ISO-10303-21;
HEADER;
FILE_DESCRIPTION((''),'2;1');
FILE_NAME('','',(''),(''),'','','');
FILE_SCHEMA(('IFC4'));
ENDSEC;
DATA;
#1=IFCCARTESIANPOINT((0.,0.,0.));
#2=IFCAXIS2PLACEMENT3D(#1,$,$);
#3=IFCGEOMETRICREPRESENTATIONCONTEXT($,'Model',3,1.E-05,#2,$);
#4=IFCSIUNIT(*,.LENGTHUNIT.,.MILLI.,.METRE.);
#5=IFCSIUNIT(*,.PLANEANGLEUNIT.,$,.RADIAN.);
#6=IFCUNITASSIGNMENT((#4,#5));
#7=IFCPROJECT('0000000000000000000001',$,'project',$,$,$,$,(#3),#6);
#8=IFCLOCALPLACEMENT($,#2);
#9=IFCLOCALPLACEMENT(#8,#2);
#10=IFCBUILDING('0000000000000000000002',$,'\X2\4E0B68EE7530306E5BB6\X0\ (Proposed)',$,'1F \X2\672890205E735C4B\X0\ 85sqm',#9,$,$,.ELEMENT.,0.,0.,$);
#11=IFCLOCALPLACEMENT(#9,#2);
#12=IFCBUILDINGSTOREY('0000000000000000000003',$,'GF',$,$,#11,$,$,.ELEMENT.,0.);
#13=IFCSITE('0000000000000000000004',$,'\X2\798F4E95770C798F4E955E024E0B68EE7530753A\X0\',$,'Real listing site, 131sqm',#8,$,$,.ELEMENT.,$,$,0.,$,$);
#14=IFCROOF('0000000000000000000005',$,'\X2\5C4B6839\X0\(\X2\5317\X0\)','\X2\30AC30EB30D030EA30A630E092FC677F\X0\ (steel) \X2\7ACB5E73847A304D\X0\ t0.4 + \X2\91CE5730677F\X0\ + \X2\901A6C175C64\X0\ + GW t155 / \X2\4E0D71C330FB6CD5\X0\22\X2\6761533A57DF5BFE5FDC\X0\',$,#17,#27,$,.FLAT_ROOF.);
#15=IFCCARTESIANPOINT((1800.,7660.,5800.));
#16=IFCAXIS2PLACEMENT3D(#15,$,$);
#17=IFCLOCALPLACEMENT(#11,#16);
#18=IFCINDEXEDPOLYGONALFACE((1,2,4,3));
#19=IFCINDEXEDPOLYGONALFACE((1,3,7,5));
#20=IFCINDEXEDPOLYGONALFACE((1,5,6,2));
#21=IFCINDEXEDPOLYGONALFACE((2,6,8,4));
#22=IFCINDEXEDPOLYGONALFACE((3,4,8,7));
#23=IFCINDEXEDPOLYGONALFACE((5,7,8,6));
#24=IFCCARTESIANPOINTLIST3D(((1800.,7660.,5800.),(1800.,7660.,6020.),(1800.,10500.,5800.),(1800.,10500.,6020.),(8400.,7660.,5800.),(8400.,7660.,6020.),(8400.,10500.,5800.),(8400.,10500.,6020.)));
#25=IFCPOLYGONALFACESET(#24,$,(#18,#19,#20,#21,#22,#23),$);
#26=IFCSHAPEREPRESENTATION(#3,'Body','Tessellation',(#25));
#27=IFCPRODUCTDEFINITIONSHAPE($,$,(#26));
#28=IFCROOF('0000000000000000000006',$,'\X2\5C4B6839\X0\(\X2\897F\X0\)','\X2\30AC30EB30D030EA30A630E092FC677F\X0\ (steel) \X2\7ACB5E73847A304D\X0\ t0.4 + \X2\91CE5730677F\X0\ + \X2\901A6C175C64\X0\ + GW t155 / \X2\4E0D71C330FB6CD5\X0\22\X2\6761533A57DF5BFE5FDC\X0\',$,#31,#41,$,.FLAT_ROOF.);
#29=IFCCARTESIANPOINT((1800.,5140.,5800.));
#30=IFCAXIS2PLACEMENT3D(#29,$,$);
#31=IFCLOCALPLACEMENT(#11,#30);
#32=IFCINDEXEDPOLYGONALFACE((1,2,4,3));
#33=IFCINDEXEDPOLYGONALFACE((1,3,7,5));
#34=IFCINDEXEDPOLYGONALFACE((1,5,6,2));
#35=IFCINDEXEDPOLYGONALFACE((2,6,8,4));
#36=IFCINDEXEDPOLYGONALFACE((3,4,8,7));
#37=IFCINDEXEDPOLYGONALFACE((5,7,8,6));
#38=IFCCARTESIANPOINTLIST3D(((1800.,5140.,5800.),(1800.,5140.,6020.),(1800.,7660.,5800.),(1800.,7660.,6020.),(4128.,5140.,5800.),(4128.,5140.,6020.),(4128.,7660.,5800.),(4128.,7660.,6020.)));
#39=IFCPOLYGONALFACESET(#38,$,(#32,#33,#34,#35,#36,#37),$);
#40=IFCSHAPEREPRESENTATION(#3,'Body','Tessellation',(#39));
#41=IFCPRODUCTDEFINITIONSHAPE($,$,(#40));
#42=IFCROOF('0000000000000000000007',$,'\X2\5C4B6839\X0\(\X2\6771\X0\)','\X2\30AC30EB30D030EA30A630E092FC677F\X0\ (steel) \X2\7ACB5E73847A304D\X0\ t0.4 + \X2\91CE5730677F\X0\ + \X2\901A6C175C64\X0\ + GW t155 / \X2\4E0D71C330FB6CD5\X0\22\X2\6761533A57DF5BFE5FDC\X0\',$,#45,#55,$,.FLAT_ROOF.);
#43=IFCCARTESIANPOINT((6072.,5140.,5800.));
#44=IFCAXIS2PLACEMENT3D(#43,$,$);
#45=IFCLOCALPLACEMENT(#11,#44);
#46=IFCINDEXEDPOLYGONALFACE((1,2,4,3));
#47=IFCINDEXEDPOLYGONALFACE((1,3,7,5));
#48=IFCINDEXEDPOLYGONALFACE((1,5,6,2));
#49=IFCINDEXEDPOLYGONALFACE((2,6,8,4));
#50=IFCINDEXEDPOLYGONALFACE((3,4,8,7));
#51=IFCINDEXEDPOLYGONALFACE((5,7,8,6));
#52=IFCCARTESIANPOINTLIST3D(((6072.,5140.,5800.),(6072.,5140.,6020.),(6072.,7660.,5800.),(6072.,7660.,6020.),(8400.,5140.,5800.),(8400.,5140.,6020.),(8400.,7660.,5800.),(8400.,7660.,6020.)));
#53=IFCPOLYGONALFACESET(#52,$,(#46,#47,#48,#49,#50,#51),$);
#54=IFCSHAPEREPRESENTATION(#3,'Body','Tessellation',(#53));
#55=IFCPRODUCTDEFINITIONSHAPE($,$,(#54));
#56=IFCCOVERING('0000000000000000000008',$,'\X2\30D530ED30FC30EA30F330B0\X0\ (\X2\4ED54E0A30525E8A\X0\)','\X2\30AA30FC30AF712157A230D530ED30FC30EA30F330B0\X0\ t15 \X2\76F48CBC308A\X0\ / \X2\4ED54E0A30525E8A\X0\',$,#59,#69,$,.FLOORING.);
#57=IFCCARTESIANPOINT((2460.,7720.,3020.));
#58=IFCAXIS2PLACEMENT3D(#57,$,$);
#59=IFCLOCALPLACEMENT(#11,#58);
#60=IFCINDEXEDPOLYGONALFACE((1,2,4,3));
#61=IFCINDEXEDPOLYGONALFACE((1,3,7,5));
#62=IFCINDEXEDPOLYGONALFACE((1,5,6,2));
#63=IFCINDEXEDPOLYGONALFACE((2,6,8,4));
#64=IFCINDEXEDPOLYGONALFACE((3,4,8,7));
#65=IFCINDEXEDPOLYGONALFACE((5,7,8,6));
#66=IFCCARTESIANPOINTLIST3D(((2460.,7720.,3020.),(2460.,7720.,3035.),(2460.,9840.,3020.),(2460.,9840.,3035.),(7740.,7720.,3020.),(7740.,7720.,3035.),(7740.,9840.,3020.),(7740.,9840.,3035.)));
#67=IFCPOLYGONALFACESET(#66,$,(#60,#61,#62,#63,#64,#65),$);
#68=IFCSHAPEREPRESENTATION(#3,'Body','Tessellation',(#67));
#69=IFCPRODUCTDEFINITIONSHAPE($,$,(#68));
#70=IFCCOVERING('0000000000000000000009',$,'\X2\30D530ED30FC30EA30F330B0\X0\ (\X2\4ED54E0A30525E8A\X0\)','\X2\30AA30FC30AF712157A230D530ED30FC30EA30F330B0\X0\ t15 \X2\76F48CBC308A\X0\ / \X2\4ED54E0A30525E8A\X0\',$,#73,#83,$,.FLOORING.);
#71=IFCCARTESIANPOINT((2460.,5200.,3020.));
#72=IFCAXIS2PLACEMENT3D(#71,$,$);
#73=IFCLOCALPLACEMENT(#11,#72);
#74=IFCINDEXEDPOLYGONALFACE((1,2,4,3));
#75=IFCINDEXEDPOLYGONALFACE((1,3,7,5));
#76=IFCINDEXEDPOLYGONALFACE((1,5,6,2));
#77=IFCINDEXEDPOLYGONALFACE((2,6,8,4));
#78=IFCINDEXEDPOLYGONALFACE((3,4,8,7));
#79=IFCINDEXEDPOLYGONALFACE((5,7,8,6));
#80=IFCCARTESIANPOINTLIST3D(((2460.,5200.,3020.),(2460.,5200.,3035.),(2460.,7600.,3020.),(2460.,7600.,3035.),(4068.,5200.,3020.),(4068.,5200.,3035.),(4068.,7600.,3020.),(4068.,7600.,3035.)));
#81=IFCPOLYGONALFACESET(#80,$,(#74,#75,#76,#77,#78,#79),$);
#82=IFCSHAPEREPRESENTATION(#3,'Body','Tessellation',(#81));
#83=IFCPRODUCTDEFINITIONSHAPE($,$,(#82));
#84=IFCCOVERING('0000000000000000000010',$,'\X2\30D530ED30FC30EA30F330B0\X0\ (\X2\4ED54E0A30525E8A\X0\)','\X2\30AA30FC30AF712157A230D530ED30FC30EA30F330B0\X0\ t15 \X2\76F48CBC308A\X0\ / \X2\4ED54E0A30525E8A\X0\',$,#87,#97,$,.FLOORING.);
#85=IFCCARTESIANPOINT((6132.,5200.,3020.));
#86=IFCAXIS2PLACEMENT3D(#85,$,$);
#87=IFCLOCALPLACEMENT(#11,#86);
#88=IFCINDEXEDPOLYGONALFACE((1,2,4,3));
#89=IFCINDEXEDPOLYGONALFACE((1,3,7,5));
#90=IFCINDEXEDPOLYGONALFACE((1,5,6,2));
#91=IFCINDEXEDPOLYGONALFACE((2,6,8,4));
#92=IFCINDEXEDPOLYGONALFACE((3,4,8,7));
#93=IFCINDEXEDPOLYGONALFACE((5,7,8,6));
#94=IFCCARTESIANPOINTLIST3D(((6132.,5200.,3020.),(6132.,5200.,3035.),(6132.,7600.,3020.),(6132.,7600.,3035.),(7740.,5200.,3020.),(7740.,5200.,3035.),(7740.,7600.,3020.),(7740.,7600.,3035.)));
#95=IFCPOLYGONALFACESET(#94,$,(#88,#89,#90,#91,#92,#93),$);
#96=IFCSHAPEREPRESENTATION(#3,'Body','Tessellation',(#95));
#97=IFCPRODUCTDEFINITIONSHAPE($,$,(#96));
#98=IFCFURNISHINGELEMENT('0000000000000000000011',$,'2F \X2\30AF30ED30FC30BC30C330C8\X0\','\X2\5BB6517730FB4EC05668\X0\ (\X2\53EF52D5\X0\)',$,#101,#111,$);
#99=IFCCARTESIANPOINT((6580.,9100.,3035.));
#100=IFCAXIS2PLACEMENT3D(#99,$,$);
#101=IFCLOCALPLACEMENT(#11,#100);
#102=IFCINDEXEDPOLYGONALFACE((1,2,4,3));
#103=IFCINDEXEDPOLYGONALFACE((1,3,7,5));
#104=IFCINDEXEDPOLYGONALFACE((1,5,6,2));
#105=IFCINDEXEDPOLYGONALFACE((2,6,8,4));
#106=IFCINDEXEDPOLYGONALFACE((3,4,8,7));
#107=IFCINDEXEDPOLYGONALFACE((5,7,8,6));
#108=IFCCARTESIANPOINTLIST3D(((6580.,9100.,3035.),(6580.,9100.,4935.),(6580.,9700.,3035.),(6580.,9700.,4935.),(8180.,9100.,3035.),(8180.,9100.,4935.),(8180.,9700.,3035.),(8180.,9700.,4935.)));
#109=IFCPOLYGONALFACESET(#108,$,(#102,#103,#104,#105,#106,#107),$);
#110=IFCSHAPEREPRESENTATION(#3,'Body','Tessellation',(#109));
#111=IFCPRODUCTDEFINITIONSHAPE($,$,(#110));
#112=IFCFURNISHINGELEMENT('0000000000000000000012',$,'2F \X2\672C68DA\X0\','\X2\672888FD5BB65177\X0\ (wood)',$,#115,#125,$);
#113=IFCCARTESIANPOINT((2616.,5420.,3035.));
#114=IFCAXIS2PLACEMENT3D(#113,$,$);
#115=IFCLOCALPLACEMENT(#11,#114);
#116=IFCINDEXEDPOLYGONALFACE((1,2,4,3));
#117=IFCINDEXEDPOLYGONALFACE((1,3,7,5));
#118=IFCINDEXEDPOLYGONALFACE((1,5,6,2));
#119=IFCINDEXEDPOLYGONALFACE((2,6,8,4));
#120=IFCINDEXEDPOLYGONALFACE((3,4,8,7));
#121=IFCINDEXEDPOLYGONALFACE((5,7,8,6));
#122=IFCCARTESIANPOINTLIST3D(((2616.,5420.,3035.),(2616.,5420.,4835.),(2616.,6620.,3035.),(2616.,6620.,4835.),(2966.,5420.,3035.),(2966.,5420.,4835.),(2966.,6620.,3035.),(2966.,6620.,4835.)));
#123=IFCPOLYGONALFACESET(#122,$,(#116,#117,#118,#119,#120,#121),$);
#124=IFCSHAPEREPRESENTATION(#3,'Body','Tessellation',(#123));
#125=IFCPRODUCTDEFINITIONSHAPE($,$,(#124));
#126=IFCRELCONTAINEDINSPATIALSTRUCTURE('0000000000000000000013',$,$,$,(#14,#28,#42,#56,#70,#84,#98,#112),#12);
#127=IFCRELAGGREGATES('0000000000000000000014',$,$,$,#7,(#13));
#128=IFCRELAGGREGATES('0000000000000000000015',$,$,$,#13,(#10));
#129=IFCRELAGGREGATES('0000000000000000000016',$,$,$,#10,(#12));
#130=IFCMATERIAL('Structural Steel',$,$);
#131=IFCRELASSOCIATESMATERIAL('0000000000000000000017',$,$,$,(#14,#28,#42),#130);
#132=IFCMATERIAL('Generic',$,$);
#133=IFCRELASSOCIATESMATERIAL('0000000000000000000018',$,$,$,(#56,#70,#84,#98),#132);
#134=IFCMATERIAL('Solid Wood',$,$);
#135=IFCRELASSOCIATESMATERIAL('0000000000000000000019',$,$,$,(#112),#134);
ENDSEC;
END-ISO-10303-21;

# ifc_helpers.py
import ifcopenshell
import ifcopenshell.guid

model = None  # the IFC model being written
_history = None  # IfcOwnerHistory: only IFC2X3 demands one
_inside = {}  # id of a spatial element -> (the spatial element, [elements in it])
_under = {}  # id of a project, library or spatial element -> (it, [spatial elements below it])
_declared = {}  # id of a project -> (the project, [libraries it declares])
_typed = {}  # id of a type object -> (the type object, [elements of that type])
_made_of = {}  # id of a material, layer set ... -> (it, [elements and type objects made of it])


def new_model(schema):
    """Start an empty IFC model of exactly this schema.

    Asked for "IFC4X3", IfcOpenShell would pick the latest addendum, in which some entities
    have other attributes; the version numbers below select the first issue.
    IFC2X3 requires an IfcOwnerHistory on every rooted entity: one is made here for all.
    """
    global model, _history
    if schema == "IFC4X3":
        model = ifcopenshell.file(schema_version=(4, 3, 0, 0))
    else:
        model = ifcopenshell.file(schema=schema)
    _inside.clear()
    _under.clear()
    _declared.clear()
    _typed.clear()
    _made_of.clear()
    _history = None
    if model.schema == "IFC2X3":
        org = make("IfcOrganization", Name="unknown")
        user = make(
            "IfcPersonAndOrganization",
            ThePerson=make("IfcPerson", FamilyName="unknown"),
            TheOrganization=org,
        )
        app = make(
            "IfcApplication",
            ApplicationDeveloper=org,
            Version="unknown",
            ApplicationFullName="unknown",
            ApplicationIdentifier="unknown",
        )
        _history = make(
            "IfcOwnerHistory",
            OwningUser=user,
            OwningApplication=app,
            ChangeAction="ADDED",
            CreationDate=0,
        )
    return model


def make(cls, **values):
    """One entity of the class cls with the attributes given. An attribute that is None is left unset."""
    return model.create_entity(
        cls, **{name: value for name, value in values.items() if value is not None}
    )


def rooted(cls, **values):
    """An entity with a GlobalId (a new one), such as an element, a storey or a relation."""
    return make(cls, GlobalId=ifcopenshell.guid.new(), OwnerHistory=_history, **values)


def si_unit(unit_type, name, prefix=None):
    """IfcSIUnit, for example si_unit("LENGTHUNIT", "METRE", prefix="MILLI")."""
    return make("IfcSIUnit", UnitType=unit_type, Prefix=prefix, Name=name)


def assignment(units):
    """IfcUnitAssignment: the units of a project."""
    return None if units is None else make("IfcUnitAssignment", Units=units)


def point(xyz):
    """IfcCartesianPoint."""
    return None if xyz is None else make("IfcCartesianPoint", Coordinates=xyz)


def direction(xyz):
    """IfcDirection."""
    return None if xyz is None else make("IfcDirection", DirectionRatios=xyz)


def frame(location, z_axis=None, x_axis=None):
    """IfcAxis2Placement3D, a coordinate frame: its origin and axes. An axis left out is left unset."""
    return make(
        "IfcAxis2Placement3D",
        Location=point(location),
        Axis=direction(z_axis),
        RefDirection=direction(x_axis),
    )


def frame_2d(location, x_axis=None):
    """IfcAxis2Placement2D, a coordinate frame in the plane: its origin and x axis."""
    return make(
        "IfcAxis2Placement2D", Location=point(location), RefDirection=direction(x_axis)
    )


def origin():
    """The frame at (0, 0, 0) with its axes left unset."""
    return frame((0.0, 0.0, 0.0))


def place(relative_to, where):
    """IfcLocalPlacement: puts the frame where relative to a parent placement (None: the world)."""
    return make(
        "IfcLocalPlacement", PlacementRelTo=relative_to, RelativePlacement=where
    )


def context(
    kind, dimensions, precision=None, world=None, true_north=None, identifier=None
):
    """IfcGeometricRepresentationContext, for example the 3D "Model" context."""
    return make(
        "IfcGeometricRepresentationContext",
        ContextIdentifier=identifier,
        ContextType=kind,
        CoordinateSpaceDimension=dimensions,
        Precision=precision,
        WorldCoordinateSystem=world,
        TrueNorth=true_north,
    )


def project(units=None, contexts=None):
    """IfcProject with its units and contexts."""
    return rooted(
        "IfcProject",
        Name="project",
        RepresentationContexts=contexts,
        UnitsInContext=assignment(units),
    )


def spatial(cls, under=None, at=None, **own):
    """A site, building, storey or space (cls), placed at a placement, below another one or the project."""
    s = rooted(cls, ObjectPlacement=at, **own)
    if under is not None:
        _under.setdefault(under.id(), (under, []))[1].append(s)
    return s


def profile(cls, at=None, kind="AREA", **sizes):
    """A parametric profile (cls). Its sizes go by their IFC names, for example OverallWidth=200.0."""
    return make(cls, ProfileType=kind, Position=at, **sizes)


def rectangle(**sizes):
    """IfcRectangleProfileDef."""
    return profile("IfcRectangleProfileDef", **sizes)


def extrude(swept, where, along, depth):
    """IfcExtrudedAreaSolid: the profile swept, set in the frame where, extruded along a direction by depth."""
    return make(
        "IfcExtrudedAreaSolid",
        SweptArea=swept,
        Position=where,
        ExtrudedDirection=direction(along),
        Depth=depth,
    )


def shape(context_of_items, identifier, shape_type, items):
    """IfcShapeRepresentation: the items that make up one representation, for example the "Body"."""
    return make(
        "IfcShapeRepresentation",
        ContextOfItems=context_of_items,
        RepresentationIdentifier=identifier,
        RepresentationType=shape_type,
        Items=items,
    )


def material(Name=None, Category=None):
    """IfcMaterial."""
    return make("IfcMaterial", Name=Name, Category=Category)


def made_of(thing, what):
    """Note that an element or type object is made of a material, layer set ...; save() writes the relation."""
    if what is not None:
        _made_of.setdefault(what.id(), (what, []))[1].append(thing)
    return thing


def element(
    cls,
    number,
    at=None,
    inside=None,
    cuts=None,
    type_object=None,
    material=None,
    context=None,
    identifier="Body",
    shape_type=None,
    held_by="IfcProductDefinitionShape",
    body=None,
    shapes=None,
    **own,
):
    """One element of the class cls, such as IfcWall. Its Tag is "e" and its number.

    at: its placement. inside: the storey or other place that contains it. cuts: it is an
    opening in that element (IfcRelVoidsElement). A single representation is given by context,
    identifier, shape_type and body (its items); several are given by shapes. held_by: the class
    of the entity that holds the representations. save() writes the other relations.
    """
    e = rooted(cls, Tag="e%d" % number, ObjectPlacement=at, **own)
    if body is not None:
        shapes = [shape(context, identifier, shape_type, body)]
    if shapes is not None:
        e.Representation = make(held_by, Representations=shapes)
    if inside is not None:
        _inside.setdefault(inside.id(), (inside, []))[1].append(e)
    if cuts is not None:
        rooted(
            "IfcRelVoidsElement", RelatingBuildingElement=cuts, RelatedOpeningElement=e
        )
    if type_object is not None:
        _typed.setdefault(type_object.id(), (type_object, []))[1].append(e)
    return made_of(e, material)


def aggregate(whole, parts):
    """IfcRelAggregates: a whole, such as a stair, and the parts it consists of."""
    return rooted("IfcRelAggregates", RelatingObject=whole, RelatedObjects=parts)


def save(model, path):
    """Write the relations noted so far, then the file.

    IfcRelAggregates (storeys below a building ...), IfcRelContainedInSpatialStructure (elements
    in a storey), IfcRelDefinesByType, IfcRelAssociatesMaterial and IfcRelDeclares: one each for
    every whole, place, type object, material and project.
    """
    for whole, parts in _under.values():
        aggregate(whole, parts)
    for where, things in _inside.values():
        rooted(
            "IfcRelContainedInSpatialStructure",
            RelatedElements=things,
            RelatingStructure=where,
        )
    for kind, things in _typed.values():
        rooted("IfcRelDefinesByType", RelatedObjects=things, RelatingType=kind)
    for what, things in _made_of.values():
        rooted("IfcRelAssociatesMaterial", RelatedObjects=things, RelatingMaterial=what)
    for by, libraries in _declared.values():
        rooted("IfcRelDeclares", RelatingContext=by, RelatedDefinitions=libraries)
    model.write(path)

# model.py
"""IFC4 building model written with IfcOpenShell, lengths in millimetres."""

from ifc_helpers import new_model, si_unit, frame, frame_2d, origin, place, context, project, spatial, rectangle, extrude, material, element, save


model = new_model("IFC4")

# Units and contexts
model_context = context("Model", 3, precision=1e-05, world=origin())
ifc_project = project(units=[si_unit("LENGTHUNIT", "METRE", prefix="MILLI"), si_unit("PLANEANGLEUNIT", "RADIAN")], contexts=[model_context])

# Site, building, storey
site_placement = place(None, origin())
site = spatial("IfcSite", under=ifc_project, at=site_placement, Name="福井県福井市下森田町", ObjectType="Real listing site, 131sqm", CompositionType="ELEMENT", RefElevation=0.0)
building_placement = place(site_placement, origin())
building = spatial("IfcBuilding", under=site, at=building_placement, Name="下森田の家 (Proposed)", ObjectType="1F 木造平屋 85sqm", CompositionType="ELEMENT", ElevationOfRefHeight=0.0, ElevationOfTerrain=0.0)
storey_placement = place(building_placement, origin())
storey = spatial("IfcBuildingStorey", under=building, at=storey_placement, Name="GF", CompositionType="ELEMENT", Elevation=0.0)

# Shared definitions
ifc_material_1 = material(Name="Solid Wood")

# Shared definitions
ifc_material_2 = material(Name="Generic")

# Roofs
ifc_material_3 = material(Name="Structural Steel")
for number, where, name in (
    (1, (1800.0, 7660.0, 5800.0), "屋根(北)"),
):
    element("IfcRoof", number, at=place(storey_placement, frame(where)), inside=storey, material=ifc_material_3, Name=name, Description="ガルバリウム鋼板 (steel) 立平葺き t0.4 + 野地板 + 通気層 + GW t155 / 不燃・法22条区域対応", PredefinedType="FLAT_ROOF", context=model_context, shape_type="SweptSolid", body=[
        extrude(rectangle(XDim=6600.0, YDim=2840.0, at=frame_2d((3300.0, 1420.0))), frame((1800.0, 7660.0, 5800.0)), (0.0, 0.0, 1.0), 220.0),
    ])
roof_1_placement = place(storey_placement, frame((1800.0, 5140.0, 5800.0)))
element("IfcRoof", 2, at=roof_1_placement, inside=storey, material=ifc_material_3, Name="屋根(西)", Description="ガルバリウム鋼板 (steel) 立平葺き t0.4 + 野地板 + 通気層 + GW t155 / 不燃・法22条区域対応", PredefinedType="FLAT_ROOF", context=model_context, shape_type="SweptSolid", body=[
    extrude(rectangle(XDim=2328.0, YDim=2520.0, at=frame_2d((1164.0, 1260.0))), frame((1800.0, 5140.0, 5800.0)), (0.0, 0.0, 1.0), 220.0),
])
roof_2_placement = place(storey_placement, frame((6072.0, 5140.0, 5800.0)))
element("IfcRoof", 3, at=roof_2_placement, inside=storey, material=ifc_material_3, Name="屋根(東)", Description="ガルバリウム鋼板 (steel) 立平葺き t0.4 + 野地板 + 通気層 + GW t155 / 不燃・法22条区域対応", PredefinedType="FLAT_ROOF", context=model_context, shape_type="SweptSolid", body=[
    extrude(rectangle(XDim=2328.0, YDim=2520.0, at=frame_2d((1164.0, 1260.0))), frame((6072.0, 5140.0, 5800.0)), (0.0, 0.0, 1.0), 220.0),
])

# Coverings
covering_1_placement = place(storey_placement, frame((2460.0, 7720.0, 3020.0)))
element("IfcCovering", 4, at=covering_1_placement, inside=storey, material=ifc_material_2, Name="フローリング (仕上げ床)", Description="オーク無垢フローリング t15 直貼り / 仕上げ床", PredefinedType="FLOORING", context=model_context, shape_type="SweptSolid", body=[
    extrude(rectangle(XDim=5280.0, YDim=2120.0, at=frame_2d((2640.0, 1060.0))), frame((2460.0, 7720.0, 3020.0)), (0.0, 0.0, 1.0), 15.0),
])
covering_2_placement = place(storey_placement, frame((2460.0, 5200.0, 3020.0)))
element("IfcCovering", 5, at=covering_2_placement, inside=storey, material=ifc_material_2, Name="フローリング (仕上げ床)", Description="オーク無垢フローリング t15 直貼り / 仕上げ床", PredefinedType="FLOORING", context=model_context, shape_type="SweptSolid", body=[
    extrude(rectangle(XDim=1608.0, YDim=2400.0, at=frame_2d((804.0, 1200.0))), frame((2460.0, 5200.0, 3020.0)), (0.0, 0.0, 1.0), 15.0),
])
covering_3_placement = place(storey_placement, frame((6132.0, 5200.0, 3020.0)))
element("IfcCovering", 6, at=covering_3_placement, inside=storey, material=ifc_material_2, Name="フローリング (仕上げ床)", Description="オーク無垢フローリング t15 直貼り / 仕上げ床", PredefinedType="FLOORING", context=model_context, shape_type="SweptSolid", body=[
    extrude(rectangle(XDim=1608.0, YDim=2400.0, at=frame_2d((804.0, 1200.0))), frame((6132.0, 5200.0, 3020.0)), (0.0, 0.0, 1.0), 15.0),
])

# Furnishing elements
furnishing_1_placement = place(storey_placement, frame((6580.0, 9100.0, 3035.0)))
element("IfcFurnishingElement", 7, at=furnishing_1_placement, inside=storey, material=ifc_material_2, Name="2F クローゼット", Description="家具・什器 (可動)", context=model_context, shape_type="SweptSolid", body=[
    extrude(rectangle(XDim=1600.0, YDim=600.0, at=frame_2d((800.0, 300.0))), frame((6580.0, 9100.0, 3035.0)), (0.0, 0.0, 1.0), 1900.0),
])
furnishing_2_placement = place(storey_placement, frame((2616.0, 5420.0, 3035.0)))
element("IfcFurnishingElement", 8, at=furnishing_2_placement, inside=storey, material=ifc_material_1, Name="2F 本棚", Description="木製家具 (wood)", context=model_context, shape_type="SweptSolid", body=[
    extrude(rectangle(XDim=350.0, YDim=1200.0, at=frame_2d((175.0, 600.0))), frame((2616.0, 5420.0, 3035.0)), (0.0, 0.0, 1.0), 1800.0),
])

save(model, "model.ifc")
